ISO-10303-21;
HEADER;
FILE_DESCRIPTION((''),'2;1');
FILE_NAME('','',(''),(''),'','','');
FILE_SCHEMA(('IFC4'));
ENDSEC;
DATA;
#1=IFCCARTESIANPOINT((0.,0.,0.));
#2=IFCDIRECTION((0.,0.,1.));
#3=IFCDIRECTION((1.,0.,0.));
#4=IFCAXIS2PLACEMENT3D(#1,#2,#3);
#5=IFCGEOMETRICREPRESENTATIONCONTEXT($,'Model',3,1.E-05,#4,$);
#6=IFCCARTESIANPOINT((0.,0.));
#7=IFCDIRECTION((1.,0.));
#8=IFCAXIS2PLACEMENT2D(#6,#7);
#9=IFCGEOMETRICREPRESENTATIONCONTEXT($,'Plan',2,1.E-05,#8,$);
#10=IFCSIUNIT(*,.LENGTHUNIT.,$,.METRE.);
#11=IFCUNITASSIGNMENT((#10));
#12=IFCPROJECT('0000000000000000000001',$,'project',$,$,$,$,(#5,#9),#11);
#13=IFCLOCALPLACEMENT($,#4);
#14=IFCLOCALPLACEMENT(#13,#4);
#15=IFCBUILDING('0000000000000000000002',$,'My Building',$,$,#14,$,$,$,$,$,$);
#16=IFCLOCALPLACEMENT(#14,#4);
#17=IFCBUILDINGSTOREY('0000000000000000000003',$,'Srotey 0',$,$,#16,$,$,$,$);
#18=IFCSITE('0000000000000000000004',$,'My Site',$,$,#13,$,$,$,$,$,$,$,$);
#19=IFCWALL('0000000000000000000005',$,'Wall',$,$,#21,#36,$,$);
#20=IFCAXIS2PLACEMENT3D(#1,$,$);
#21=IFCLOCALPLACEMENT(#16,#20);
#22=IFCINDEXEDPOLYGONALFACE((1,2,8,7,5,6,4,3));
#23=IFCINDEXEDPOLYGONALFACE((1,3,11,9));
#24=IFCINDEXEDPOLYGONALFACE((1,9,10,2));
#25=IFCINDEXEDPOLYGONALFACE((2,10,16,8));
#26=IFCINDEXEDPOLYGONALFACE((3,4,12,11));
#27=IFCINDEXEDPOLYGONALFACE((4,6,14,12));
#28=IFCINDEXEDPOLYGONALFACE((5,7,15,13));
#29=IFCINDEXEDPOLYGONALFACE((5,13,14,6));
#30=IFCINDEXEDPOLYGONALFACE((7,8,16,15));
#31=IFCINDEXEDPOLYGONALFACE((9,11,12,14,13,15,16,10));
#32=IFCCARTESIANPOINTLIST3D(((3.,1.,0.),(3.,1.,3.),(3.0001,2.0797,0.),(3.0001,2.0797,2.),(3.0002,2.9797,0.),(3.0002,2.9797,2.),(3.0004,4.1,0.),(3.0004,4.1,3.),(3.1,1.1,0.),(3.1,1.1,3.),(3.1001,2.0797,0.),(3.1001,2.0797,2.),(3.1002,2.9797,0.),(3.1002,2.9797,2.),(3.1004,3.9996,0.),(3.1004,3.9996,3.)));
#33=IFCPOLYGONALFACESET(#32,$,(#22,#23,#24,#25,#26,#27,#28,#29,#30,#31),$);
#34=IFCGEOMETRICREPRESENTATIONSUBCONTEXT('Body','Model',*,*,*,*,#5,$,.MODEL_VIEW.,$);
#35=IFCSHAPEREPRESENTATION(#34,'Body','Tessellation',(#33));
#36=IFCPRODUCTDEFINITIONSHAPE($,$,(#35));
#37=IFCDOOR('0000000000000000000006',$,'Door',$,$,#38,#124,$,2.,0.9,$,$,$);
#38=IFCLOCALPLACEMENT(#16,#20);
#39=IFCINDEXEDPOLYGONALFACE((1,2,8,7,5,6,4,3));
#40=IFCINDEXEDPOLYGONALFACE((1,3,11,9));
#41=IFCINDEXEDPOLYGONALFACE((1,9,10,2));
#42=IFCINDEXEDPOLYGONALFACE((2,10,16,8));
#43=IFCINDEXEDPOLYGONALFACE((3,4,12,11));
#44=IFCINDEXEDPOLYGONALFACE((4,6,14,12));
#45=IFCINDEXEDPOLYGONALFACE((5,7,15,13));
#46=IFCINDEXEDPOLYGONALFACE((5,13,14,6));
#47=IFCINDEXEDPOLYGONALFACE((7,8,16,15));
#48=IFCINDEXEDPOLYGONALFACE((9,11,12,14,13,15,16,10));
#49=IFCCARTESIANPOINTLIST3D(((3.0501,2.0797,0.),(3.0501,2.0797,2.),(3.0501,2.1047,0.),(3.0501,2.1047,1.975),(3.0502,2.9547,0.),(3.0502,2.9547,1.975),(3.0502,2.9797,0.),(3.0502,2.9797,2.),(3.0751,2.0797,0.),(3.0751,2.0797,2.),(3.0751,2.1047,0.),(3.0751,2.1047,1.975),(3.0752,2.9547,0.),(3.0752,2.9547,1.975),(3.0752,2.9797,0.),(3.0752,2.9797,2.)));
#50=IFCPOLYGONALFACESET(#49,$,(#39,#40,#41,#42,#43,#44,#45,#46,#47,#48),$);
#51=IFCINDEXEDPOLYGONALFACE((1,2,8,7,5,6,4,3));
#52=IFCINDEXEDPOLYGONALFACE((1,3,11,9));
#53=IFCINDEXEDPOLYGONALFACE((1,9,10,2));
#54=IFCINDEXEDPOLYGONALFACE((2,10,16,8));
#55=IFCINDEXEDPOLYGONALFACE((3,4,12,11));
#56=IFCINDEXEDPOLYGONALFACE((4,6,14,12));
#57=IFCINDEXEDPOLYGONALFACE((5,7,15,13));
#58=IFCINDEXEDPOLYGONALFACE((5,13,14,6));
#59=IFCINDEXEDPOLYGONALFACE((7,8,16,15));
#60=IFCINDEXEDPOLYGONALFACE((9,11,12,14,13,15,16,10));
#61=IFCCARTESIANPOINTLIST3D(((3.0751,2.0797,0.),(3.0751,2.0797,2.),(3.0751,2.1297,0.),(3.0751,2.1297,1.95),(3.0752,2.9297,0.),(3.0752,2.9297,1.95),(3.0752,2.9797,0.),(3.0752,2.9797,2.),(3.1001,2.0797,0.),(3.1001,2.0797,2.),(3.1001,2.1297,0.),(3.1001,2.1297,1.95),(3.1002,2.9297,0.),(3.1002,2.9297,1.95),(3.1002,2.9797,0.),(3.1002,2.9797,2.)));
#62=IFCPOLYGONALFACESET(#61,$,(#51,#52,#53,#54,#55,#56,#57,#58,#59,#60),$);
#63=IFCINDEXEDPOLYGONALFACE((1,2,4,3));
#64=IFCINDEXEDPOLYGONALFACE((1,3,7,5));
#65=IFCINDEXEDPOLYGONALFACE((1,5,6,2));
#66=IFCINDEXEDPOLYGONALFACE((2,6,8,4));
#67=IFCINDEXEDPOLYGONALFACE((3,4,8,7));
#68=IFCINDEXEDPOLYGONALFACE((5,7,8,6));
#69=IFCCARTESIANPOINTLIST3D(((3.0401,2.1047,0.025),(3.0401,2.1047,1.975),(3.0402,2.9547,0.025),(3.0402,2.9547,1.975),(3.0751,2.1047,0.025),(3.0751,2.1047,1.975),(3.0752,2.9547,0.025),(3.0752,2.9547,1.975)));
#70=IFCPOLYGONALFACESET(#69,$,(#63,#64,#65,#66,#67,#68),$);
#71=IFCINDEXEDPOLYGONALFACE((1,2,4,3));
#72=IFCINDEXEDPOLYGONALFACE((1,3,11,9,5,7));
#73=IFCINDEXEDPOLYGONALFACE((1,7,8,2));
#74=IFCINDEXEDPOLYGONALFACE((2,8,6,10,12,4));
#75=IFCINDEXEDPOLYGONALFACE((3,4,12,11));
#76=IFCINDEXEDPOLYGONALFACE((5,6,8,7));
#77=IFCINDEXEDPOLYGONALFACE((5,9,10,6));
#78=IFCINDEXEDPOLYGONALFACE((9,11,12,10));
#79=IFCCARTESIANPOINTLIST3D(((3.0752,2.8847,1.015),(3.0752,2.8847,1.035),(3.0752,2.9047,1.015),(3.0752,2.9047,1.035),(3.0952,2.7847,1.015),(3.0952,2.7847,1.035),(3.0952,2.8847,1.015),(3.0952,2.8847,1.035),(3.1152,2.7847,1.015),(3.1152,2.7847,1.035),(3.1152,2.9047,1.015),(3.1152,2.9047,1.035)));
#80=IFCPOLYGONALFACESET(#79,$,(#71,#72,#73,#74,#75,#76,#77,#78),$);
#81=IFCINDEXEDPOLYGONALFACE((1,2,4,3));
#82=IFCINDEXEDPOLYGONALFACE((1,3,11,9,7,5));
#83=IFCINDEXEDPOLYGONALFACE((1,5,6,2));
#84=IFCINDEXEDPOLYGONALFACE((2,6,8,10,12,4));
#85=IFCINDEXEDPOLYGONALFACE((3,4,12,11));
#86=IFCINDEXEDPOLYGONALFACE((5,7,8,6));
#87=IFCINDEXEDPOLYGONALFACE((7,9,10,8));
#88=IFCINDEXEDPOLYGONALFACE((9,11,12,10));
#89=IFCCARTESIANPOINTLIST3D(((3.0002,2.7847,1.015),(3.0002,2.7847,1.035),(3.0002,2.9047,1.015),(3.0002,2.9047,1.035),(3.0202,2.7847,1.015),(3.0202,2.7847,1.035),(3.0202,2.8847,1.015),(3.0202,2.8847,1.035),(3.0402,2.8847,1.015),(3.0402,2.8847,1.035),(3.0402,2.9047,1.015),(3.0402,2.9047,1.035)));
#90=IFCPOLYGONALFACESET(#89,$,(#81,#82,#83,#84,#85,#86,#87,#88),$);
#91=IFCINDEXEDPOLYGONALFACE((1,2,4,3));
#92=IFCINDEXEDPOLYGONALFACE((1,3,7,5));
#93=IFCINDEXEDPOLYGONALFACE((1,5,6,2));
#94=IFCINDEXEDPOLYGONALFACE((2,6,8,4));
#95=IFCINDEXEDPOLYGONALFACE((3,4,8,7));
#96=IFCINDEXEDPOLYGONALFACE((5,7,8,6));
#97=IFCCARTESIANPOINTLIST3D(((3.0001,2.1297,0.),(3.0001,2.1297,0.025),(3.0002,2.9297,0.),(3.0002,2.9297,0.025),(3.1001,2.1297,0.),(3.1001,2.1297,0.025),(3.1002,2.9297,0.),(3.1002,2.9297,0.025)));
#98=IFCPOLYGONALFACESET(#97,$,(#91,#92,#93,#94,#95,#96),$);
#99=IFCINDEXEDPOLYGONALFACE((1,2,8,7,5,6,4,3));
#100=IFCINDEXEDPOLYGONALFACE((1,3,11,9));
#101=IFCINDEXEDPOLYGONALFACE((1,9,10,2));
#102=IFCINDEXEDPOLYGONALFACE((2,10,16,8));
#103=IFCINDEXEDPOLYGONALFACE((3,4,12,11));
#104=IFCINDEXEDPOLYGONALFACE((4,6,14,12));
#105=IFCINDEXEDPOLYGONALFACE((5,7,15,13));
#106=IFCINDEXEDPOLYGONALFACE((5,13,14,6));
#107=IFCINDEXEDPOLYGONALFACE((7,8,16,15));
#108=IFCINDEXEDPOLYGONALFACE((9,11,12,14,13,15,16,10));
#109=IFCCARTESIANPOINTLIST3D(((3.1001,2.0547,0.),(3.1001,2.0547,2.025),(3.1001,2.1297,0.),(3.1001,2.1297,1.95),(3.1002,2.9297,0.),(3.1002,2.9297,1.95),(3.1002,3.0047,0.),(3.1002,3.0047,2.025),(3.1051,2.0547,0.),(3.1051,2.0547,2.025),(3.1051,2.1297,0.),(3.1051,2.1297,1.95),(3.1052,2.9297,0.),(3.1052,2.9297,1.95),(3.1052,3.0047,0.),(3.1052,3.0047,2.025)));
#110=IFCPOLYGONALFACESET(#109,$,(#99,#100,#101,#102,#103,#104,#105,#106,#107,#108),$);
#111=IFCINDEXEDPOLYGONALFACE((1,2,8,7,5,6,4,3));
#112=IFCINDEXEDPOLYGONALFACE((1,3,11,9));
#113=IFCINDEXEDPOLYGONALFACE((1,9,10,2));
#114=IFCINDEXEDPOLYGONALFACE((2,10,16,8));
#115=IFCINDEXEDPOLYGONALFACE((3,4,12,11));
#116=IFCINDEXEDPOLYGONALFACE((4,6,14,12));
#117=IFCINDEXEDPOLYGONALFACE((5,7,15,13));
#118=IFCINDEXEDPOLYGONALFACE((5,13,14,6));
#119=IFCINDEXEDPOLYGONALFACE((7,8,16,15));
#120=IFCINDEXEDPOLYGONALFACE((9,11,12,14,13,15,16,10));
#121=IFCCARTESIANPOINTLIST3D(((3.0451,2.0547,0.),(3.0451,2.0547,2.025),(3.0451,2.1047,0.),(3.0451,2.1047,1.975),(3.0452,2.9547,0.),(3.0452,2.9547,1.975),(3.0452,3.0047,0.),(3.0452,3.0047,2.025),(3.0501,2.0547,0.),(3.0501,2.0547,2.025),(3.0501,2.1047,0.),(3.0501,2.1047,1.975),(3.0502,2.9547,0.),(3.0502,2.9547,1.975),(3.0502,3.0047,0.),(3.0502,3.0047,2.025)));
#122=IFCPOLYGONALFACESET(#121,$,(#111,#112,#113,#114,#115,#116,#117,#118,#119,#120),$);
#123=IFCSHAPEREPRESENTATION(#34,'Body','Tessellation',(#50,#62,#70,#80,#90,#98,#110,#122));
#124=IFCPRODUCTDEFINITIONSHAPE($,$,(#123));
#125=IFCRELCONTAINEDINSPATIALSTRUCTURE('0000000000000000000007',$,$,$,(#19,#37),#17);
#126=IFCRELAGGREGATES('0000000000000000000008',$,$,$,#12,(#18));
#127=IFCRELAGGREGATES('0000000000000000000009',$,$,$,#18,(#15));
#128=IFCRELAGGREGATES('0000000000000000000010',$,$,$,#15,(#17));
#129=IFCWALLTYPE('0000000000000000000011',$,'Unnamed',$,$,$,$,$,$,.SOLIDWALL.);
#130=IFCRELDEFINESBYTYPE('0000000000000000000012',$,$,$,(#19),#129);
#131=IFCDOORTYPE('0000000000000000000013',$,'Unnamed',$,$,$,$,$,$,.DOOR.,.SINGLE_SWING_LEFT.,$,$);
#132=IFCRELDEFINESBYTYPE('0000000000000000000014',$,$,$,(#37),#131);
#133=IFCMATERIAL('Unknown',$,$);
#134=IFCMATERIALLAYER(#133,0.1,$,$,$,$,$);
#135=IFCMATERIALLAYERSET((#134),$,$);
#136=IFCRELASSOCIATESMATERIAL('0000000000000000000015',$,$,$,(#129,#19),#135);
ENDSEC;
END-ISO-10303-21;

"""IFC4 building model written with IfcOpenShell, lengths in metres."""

from ifc_helpers import new_model, entity, si_unit, frame, origin_with_axes, origin_2d_with_axis, place, context, subcontext, project, spatial, line, indexed_curve, outline, extrude, shape, source, transform, mapped, material, layer, layer_set, layer_usage, type_object, type_shapes, element, fill, save


model = new_model("IFC4")

# Units and contexts
model_context = context("Model", 3, precision=1e-05, world=origin_with_axes())
plan_context = context("Plan", 2, precision=1e-05, world=origin_2d_with_axis())
body_context_1 = subcontext(model_context, "Body", "Model", "MODEL_VIEW")
body_context_2 = subcontext(plan_context, "Body", "Plan", "PLAN_VIEW")
ifc_project = project(units=[si_unit("LENGTHUNIT", "METRE")], contexts=[model_context, plan_context])

# Site, building, storey
site_placement = place(None, origin_with_axes())
site = spatial("IfcSite", under=ifc_project, at=site_placement, Name="My Site")
building_placement = place(site_placement, origin_with_axes())
building = spatial("IfcBuilding", under=site, at=building_placement, Name="My Building")
storey_placement = place(building_placement, origin_with_axes())
storey = spatial("IfcBuildingStorey", under=building, at=storey_placement, Name="Srotey 0")

# Shared definitions
ifc_material = material(Name="Unknown")
ifc_layer = layer(ifc_material, 0.1)
ifc_layer_set = layer_set([ifc_layer])
wall_type = type_object("IfcWallType", Name="Unnamed", PredefinedType="SOLIDWALL", material=ifc_layer_set)

# Shared definitions
shared_shape_1 = source(origin_with_axes(), body_context_1, "Body", "SweptSolid", [
    extrude(outline(indexed_curve([(0.0, 0.0), (0.9, 0.0), (0.9, 2.0), (0.0, 2.0)], segments=[line(1, 2, 3, 4, 1)])), frame((0.0, -0.6, 0.0), z_axis=(0.0, -1.0, 0.0), x_axis=(1.0, 0.0, 0.0)), (0.0, 0.0, -1.0), 1.2),
])
door_type = type_object("IfcDoorType", Name="Unnamed", OperationType="SINGLE_SWING_LEFT", PredefinedType="DOOR")
shared_shape_2 = source(origin_with_axes(), body_context_1, "Body", "SweptSolid", [
    extrude(outline(indexed_curve([(0.0, 0.0), (0.0, 2.0), (0.9, 2.0), (0.9, 0.0), (0.875, 0.0), (0.875, 1.975), (0.025, 1.975), (0.025, 0.0)], segments=[line(1, 2, 3, 4, 5, 6, 7, 8, 1)])), frame((0.0, 0.025, 0.0), z_axis=(0.0, -1.0, 0.0), x_axis=(1.0, 0.0, 0.0)), (0.0, 0.0, -1.0), 0.025),
    extrude(outline(indexed_curve([(0.0, 0.0), (0.0, 2.0), (0.9, 2.0), (0.9, 0.0), (0.85, 0.0), (0.85, 1.95), (0.05, 1.95), (0.05, 0.0)], segments=[line(1, 2, 3, 4, 5, 6, 7, 8, 1)])), frame((0.0, 0.0, 0.0), z_axis=(0.0, -1.0, 0.0), x_axis=(1.0, 0.0, 0.0)), (0.0, 0.0, -1.0), 0.025),
    extrude(outline(indexed_curve([(0.0, 0.0), (0.85, 0.0), (0.85, 0.035), (0.0, 0.035)], segments=[line(1, 2, 3, 4, 1)])), frame((0.025, 0.025, 0.025), z_axis=(0.0, 0.0, 1.0), x_axis=(1.0, 0.0, 0.0)), (0.0, 0.0, 1.0), 1.95),
    extrude(outline(indexed_curve([(0.0, 0.0), (0.0, -0.04), (-0.12, -0.04), (-0.12, -0.02), (-0.02, -0.02), (-0.02, 0.0)], segments=[line(1, 2, 3, 4, 5, 6, 1)])), frame((0.825, 0.025, 1.015), z_axis=(0.0, 0.0, 1.0), x_axis=(1.0, 0.0, 0.0)), (0.0, 0.0, 1.0), 0.02),
    extrude(outline(indexed_curve([(0.0, 0.0), (0.0, 0.04), (-0.12, 0.04), (-0.12, 0.02), (-0.02, 0.02), (-0.02, 0.0)], segments=[line(1, 2, 3, 4, 5, 6, 1)])), frame((0.825, 0.06, 1.015), z_axis=(0.0, 0.0, 1.0), x_axis=(1.0, 0.0, 0.0)), (0.0, 0.0, 1.0), 0.02),
    extrude(outline(indexed_curve([(0.0, 0.0), (0.8, 0.0), (0.8, 0.1), (0.0, 0.1)], segments=[line(1, 2, 3, 4, 1)])), frame((0.05, 0.0, 0.0), z_axis=(0.0, 0.0, 1.0), x_axis=(1.0, 0.0, 0.0)), (0.0, 0.0, 1.0), 0.025),
    extrude(outline(indexed_curve([(0.0, 0.0), (0.0, 2.025), (0.95, 2.025), (0.95, 0.0), (0.875, 0.0), (0.875, 1.95), (0.075, 1.95), (0.075, 0.0)], segments=[line(1, 2, 3, 4, 5, 6, 7, 8, 1)])), frame((-0.025, -0.005, 0.0), z_axis=(0.0, -1.0, 0.0), x_axis=(1.0, 0.0, 0.0)), (0.0, 0.0, -1.0), 0.005),
    extrude(outline(indexed_curve([(0.0, 0.0), (0.0, 2.025), (0.95, 2.025), (0.95, 0.0), (0.9, 0.0), (0.9, 1.975), (0.05, 1.975), (0.05, 0.0)], segments=[line(1, 2, 3, 4, 5, 6, 7, 8, 1)])), frame((-0.025, 0.05, 0.0), z_axis=(0.0, -1.0, 0.0), x_axis=(1.0, 0.0, 0.0)), (0.0, 0.0, -1.0), 0.005),
])
shared_shape_3 = source(origin_with_axes(), body_context_2, "Body", "Curve2D", [
    entity("IfcIndexedPolyCurve", entity("IfcCartesianPointList2D", [[0.0, 0.0], [0.0, 0.05], [0.025, 0.05], [0.025, 0.025], [0.05, 0.025], [0.05, 0.0]]), [entity("IfcLineIndex", [1, 2, 3, 4, 5, 6, 1])]),
    entity("IfcIndexedPolyCurve", entity("IfcCartesianPointList2D", [[0.9, 0.0], [0.9, 0.05], [0.875, 0.05], [0.875, 0.025], [0.85, 0.025], [0.85, 0.0]]), [entity("IfcLineIndex", [1, 2, 3, 4, 5, 6, 1])]),
    entity("IfcTrimmedCurve", entity("IfcEllipse", entity("IfcAxis2Placement2D", entity("IfcCartesianPoint", [0.06, 0.05]), entity("IfcDirection", [1.0, 0.0])), 0.815, 0.85), [entity("IfcCartesianPoint", [0.875, 0.05])], [entity("IfcCartesianPoint", [0.06, 0.9])], True, "CARTESIAN"),
    entity("IfcIndexedPolyCurve", entity("IfcCartesianPointList2D", [[0.025, 0.05], [0.06, 0.05], [0.06, 0.9], [0.025, 0.9]]), [entity("IfcLineIndex", [1, 2, 3, 4, 1])]),
])
type_shapes(door_type, [shared_shape_2, shared_shape_3])

# Wall, opening, door
ifc_layer_usage_1 = layer_usage(ifc_layer_set, "AXIS2", "POSITIVE", 0.0)
wall_1_placement = place(storey_placement, frame((3.0004, 4.0, 0.0), z_axis=(0.0, 0.0, 1.0), x_axis=(-0.000122, -1.0, 0.0)))
wall_1 = element("IfcWall", 1, at=wall_1_placement, inside=storey, type_object=wall_type, material=ifc_layer_usage_1, Name="Wall", context=body_context_1, shape_type="SweptSolid", body=[
    extrude(outline(indexed_curve([(-0.1, 0.0), (0.0004, 0.1), (2.9, 0.1), (3.0, 0.0)], segments=[line(1, 2, 3, 4, 1)])), origin_with_axes(), (0.0, 0.0, 1.0), 3.0),
])
opening_1_placement = place(wall_1_placement, frame((1.9203, 0.1, 0.0), z_axis=(0.0, 0.0, 1.0), x_axis=(-1.0, 0.0, 0.0)))
opening_1 = element("IfcOpeningElement", 2, at=opening_1_placement, cuts=wall_1, PredefinedType="OPENING", context=body_context_1, shape_type="MappedRepresentation", body=[
    mapped(shared_shape_1, transform((0.0, 0.0, 0.0), x_axis=(1.0, 0.0, 0.0), y_axis=(0.0, 1.0, 0.0), z_axis=(0.0, 0.0, 1.0), scale=1.0)),
])
door_1_placement = place(opening_1_placement, frame((0.0, 0.0, 0.0), z_axis=(0.0, 0.0, 1.0), x_axis=(1.0, 0.0, 0.0)))
door_1 = element("IfcDoor", 3, at=door_1_placement, inside=storey, type_object=door_type, Name="Door", OverallHeight=2.0, OverallWidth=0.9, shapes=[
    shape(body_context_1, "Body", "MappedRepresentation", [mapped(shared_shape_2, transform((0.0, 0.0, 0.0), x_axis=(1.0, 0.0, 0.0), y_axis=(0.0, 1.0, 0.0), z_axis=(0.0, 0.0, 1.0), scale=1.0))]),
    shape(body_context_2, "Body", "MappedRepresentation", [mapped(shared_shape_3, transform((0.0, 0.0, 0.0), x_axis=(1.0, 0.0, 0.0), y_axis=(0.0, 1.0, 0.0), z_axis=(0.0, 0.0, 1.0), scale=1.0))]),
])
fill(opening_1, door_1)

save(model, "model.ifc")
